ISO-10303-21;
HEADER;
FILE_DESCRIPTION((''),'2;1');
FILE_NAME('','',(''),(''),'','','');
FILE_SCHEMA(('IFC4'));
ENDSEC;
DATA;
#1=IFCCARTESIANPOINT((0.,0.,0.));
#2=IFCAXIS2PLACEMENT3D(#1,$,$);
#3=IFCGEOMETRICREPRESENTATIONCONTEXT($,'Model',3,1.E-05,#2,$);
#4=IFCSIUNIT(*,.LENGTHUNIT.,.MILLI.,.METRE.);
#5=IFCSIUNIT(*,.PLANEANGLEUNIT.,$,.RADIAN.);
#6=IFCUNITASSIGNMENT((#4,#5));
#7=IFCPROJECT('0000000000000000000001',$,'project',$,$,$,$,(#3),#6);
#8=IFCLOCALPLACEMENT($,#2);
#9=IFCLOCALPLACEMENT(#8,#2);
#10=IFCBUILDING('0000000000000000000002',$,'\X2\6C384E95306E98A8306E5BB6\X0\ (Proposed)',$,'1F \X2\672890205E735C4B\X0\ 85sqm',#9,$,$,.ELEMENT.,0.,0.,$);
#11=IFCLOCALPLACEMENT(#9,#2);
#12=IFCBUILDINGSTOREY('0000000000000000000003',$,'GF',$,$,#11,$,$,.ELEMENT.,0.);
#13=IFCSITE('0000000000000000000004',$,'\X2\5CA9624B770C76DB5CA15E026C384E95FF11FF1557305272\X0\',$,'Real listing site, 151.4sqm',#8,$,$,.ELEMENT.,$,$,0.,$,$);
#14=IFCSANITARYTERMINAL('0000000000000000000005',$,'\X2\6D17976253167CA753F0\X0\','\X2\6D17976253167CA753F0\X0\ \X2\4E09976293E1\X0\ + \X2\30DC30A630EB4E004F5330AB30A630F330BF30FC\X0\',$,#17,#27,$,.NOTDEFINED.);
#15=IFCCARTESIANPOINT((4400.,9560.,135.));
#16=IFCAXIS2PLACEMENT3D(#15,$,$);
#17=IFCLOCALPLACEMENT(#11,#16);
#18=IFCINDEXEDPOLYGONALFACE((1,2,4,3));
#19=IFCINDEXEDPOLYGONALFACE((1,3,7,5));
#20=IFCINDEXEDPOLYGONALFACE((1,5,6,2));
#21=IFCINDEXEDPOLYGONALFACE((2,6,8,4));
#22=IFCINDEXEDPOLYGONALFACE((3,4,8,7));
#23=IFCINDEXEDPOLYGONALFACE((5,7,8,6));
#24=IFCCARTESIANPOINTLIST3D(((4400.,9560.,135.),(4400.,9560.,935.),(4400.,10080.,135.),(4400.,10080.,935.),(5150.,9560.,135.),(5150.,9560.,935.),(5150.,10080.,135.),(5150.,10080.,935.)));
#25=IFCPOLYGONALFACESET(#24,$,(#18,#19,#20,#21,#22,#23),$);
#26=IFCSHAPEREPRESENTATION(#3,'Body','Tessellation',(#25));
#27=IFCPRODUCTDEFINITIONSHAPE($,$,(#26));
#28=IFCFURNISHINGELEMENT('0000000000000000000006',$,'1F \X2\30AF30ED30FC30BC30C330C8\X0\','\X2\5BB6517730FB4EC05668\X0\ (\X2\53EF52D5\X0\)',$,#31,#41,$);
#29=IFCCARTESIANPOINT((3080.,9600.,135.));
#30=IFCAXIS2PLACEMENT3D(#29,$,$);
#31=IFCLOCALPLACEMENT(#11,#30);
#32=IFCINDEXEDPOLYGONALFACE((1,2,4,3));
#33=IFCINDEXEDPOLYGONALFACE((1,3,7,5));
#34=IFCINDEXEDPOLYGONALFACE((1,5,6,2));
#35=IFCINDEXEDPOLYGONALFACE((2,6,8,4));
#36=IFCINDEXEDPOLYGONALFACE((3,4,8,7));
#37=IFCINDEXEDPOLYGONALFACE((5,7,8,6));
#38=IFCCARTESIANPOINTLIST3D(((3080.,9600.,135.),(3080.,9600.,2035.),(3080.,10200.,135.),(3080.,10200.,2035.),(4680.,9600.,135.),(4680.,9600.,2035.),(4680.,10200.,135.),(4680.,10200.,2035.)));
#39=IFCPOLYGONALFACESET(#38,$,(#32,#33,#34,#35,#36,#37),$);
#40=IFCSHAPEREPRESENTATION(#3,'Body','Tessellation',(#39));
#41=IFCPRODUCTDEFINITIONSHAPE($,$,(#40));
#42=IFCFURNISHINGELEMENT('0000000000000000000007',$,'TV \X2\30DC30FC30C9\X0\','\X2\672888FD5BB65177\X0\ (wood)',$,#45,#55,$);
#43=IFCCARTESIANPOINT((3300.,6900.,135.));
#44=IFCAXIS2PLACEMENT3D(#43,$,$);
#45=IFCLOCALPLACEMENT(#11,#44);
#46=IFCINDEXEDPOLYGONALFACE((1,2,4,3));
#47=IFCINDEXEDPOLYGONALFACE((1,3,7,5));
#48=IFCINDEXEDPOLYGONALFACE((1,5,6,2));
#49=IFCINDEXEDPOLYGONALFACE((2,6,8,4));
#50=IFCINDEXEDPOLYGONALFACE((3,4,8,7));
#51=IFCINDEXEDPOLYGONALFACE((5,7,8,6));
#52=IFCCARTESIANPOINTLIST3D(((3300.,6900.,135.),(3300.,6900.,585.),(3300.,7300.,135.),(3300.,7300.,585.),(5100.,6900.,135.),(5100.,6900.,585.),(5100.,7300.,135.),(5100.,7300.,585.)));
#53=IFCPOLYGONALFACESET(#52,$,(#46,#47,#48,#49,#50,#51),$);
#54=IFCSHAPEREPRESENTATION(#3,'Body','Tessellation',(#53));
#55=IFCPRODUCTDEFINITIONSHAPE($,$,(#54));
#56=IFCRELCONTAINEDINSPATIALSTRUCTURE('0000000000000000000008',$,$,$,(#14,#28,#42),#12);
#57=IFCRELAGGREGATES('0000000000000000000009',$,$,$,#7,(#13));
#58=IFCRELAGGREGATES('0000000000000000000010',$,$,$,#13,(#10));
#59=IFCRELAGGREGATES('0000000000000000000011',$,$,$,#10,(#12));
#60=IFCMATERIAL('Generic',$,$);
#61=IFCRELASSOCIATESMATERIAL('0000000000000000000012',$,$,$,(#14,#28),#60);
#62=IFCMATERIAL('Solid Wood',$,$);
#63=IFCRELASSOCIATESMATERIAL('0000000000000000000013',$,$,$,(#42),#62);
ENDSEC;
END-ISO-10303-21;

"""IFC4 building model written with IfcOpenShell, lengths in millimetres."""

from ifc_helpers import new_model, si_unit, frame, frame_2d, origin, place, context, project, spatial, rectangle, extrude, material, element, save


model = new_model("IFC4")

# Units and contexts
model_context = context("Model", 3, precision=1e-05, world=origin())
ifc_project = project(units=[si_unit("LENGTHUNIT", "METRE", prefix="MILLI"), si_unit("PLANEANGLEUNIT", "RADIAN")], contexts=[model_context])

# Site, building, storey
site_placement = place(None, origin())
site = spatial("IfcSite", under=ifc_project, at=site_placement, Name="岩手県盛岡市永井１５地割", ObjectType="Real listing site, 151.4sqm", CompositionType="ELEMENT", RefElevation=0.0)
building_placement = place(site_placement, origin())
building = spatial("IfcBuilding", under=site, at=building_placement, Name="永井の風の家 (Proposed)", ObjectType="1F 木造平屋 85sqm", CompositionType="ELEMENT", ElevationOfRefHeight=0.0, ElevationOfTerrain=0.0)
storey_placement = place(building_placement, origin())
storey = spatial("IfcBuildingStorey", under=building, at=storey_placement, Name="GF", CompositionType="ELEMENT", Elevation=0.0)

# Shared definitions
ifc_material_1 = material(Name="Solid Wood")

# Shared definitions
ifc_material_2 = material(Name="Generic")

# Sanitary terminal
sanitary_terminal_1_placement = place(storey_placement, frame((4400.0, 9560.0, 135.0)))
element("IfcSanitaryTerminal", 1, at=sanitary_terminal_1_placement, inside=storey, material=ifc_material_2, Name="洗面化粧台", Description="洗面化粧台 三面鏡 + ボウル一体カウンター", PredefinedType="NOTDEFINED", context=model_context, shape_type="SweptSolid", body=[
    extrude(rectangle(XDim=750.0, YDim=520.0, at=frame_2d((375.0, 260.0))), frame((4400.0, 9560.0, 135.0)), (0.0, 0.0, 1.0), 800.0),
])

# Furnishing elements
furnishing_1_placement = place(storey_placement, frame((3080.0, 9600.0, 135.0)))
element("IfcFurnishingElement", 2, at=furnishing_1_placement, inside=storey, material=ifc_material_2, Name="1F クローゼット", Description="家具・什器 (可動)", context=model_context, shape_type="SweptSolid", body=[
    extrude(rectangle(XDim=1600.0, YDim=600.0, at=frame_2d((800.0, 300.0))), frame((3080.0, 9600.0, 135.0)), (0.0, 0.0, 1.0), 1900.0),
])
furnishing_2_placement = place(storey_placement, frame((3300.0, 6900.0, 135.0)))
element("IfcFurnishingElement", 3, at=furnishing_2_placement, inside=storey, material=ifc_material_1, Name="TV ボード", Description="木製家具 (wood)", context=model_context, shape_type="SweptSolid", body=[
    extrude(rectangle(XDim=1800.0, YDim=400.0, at=frame_2d((900.0, 200.0))), frame((3300.0, 6900.0, 135.0)), (0.0, 0.0, 1.0), 450.0),
])

save(model, "model.ifc")
